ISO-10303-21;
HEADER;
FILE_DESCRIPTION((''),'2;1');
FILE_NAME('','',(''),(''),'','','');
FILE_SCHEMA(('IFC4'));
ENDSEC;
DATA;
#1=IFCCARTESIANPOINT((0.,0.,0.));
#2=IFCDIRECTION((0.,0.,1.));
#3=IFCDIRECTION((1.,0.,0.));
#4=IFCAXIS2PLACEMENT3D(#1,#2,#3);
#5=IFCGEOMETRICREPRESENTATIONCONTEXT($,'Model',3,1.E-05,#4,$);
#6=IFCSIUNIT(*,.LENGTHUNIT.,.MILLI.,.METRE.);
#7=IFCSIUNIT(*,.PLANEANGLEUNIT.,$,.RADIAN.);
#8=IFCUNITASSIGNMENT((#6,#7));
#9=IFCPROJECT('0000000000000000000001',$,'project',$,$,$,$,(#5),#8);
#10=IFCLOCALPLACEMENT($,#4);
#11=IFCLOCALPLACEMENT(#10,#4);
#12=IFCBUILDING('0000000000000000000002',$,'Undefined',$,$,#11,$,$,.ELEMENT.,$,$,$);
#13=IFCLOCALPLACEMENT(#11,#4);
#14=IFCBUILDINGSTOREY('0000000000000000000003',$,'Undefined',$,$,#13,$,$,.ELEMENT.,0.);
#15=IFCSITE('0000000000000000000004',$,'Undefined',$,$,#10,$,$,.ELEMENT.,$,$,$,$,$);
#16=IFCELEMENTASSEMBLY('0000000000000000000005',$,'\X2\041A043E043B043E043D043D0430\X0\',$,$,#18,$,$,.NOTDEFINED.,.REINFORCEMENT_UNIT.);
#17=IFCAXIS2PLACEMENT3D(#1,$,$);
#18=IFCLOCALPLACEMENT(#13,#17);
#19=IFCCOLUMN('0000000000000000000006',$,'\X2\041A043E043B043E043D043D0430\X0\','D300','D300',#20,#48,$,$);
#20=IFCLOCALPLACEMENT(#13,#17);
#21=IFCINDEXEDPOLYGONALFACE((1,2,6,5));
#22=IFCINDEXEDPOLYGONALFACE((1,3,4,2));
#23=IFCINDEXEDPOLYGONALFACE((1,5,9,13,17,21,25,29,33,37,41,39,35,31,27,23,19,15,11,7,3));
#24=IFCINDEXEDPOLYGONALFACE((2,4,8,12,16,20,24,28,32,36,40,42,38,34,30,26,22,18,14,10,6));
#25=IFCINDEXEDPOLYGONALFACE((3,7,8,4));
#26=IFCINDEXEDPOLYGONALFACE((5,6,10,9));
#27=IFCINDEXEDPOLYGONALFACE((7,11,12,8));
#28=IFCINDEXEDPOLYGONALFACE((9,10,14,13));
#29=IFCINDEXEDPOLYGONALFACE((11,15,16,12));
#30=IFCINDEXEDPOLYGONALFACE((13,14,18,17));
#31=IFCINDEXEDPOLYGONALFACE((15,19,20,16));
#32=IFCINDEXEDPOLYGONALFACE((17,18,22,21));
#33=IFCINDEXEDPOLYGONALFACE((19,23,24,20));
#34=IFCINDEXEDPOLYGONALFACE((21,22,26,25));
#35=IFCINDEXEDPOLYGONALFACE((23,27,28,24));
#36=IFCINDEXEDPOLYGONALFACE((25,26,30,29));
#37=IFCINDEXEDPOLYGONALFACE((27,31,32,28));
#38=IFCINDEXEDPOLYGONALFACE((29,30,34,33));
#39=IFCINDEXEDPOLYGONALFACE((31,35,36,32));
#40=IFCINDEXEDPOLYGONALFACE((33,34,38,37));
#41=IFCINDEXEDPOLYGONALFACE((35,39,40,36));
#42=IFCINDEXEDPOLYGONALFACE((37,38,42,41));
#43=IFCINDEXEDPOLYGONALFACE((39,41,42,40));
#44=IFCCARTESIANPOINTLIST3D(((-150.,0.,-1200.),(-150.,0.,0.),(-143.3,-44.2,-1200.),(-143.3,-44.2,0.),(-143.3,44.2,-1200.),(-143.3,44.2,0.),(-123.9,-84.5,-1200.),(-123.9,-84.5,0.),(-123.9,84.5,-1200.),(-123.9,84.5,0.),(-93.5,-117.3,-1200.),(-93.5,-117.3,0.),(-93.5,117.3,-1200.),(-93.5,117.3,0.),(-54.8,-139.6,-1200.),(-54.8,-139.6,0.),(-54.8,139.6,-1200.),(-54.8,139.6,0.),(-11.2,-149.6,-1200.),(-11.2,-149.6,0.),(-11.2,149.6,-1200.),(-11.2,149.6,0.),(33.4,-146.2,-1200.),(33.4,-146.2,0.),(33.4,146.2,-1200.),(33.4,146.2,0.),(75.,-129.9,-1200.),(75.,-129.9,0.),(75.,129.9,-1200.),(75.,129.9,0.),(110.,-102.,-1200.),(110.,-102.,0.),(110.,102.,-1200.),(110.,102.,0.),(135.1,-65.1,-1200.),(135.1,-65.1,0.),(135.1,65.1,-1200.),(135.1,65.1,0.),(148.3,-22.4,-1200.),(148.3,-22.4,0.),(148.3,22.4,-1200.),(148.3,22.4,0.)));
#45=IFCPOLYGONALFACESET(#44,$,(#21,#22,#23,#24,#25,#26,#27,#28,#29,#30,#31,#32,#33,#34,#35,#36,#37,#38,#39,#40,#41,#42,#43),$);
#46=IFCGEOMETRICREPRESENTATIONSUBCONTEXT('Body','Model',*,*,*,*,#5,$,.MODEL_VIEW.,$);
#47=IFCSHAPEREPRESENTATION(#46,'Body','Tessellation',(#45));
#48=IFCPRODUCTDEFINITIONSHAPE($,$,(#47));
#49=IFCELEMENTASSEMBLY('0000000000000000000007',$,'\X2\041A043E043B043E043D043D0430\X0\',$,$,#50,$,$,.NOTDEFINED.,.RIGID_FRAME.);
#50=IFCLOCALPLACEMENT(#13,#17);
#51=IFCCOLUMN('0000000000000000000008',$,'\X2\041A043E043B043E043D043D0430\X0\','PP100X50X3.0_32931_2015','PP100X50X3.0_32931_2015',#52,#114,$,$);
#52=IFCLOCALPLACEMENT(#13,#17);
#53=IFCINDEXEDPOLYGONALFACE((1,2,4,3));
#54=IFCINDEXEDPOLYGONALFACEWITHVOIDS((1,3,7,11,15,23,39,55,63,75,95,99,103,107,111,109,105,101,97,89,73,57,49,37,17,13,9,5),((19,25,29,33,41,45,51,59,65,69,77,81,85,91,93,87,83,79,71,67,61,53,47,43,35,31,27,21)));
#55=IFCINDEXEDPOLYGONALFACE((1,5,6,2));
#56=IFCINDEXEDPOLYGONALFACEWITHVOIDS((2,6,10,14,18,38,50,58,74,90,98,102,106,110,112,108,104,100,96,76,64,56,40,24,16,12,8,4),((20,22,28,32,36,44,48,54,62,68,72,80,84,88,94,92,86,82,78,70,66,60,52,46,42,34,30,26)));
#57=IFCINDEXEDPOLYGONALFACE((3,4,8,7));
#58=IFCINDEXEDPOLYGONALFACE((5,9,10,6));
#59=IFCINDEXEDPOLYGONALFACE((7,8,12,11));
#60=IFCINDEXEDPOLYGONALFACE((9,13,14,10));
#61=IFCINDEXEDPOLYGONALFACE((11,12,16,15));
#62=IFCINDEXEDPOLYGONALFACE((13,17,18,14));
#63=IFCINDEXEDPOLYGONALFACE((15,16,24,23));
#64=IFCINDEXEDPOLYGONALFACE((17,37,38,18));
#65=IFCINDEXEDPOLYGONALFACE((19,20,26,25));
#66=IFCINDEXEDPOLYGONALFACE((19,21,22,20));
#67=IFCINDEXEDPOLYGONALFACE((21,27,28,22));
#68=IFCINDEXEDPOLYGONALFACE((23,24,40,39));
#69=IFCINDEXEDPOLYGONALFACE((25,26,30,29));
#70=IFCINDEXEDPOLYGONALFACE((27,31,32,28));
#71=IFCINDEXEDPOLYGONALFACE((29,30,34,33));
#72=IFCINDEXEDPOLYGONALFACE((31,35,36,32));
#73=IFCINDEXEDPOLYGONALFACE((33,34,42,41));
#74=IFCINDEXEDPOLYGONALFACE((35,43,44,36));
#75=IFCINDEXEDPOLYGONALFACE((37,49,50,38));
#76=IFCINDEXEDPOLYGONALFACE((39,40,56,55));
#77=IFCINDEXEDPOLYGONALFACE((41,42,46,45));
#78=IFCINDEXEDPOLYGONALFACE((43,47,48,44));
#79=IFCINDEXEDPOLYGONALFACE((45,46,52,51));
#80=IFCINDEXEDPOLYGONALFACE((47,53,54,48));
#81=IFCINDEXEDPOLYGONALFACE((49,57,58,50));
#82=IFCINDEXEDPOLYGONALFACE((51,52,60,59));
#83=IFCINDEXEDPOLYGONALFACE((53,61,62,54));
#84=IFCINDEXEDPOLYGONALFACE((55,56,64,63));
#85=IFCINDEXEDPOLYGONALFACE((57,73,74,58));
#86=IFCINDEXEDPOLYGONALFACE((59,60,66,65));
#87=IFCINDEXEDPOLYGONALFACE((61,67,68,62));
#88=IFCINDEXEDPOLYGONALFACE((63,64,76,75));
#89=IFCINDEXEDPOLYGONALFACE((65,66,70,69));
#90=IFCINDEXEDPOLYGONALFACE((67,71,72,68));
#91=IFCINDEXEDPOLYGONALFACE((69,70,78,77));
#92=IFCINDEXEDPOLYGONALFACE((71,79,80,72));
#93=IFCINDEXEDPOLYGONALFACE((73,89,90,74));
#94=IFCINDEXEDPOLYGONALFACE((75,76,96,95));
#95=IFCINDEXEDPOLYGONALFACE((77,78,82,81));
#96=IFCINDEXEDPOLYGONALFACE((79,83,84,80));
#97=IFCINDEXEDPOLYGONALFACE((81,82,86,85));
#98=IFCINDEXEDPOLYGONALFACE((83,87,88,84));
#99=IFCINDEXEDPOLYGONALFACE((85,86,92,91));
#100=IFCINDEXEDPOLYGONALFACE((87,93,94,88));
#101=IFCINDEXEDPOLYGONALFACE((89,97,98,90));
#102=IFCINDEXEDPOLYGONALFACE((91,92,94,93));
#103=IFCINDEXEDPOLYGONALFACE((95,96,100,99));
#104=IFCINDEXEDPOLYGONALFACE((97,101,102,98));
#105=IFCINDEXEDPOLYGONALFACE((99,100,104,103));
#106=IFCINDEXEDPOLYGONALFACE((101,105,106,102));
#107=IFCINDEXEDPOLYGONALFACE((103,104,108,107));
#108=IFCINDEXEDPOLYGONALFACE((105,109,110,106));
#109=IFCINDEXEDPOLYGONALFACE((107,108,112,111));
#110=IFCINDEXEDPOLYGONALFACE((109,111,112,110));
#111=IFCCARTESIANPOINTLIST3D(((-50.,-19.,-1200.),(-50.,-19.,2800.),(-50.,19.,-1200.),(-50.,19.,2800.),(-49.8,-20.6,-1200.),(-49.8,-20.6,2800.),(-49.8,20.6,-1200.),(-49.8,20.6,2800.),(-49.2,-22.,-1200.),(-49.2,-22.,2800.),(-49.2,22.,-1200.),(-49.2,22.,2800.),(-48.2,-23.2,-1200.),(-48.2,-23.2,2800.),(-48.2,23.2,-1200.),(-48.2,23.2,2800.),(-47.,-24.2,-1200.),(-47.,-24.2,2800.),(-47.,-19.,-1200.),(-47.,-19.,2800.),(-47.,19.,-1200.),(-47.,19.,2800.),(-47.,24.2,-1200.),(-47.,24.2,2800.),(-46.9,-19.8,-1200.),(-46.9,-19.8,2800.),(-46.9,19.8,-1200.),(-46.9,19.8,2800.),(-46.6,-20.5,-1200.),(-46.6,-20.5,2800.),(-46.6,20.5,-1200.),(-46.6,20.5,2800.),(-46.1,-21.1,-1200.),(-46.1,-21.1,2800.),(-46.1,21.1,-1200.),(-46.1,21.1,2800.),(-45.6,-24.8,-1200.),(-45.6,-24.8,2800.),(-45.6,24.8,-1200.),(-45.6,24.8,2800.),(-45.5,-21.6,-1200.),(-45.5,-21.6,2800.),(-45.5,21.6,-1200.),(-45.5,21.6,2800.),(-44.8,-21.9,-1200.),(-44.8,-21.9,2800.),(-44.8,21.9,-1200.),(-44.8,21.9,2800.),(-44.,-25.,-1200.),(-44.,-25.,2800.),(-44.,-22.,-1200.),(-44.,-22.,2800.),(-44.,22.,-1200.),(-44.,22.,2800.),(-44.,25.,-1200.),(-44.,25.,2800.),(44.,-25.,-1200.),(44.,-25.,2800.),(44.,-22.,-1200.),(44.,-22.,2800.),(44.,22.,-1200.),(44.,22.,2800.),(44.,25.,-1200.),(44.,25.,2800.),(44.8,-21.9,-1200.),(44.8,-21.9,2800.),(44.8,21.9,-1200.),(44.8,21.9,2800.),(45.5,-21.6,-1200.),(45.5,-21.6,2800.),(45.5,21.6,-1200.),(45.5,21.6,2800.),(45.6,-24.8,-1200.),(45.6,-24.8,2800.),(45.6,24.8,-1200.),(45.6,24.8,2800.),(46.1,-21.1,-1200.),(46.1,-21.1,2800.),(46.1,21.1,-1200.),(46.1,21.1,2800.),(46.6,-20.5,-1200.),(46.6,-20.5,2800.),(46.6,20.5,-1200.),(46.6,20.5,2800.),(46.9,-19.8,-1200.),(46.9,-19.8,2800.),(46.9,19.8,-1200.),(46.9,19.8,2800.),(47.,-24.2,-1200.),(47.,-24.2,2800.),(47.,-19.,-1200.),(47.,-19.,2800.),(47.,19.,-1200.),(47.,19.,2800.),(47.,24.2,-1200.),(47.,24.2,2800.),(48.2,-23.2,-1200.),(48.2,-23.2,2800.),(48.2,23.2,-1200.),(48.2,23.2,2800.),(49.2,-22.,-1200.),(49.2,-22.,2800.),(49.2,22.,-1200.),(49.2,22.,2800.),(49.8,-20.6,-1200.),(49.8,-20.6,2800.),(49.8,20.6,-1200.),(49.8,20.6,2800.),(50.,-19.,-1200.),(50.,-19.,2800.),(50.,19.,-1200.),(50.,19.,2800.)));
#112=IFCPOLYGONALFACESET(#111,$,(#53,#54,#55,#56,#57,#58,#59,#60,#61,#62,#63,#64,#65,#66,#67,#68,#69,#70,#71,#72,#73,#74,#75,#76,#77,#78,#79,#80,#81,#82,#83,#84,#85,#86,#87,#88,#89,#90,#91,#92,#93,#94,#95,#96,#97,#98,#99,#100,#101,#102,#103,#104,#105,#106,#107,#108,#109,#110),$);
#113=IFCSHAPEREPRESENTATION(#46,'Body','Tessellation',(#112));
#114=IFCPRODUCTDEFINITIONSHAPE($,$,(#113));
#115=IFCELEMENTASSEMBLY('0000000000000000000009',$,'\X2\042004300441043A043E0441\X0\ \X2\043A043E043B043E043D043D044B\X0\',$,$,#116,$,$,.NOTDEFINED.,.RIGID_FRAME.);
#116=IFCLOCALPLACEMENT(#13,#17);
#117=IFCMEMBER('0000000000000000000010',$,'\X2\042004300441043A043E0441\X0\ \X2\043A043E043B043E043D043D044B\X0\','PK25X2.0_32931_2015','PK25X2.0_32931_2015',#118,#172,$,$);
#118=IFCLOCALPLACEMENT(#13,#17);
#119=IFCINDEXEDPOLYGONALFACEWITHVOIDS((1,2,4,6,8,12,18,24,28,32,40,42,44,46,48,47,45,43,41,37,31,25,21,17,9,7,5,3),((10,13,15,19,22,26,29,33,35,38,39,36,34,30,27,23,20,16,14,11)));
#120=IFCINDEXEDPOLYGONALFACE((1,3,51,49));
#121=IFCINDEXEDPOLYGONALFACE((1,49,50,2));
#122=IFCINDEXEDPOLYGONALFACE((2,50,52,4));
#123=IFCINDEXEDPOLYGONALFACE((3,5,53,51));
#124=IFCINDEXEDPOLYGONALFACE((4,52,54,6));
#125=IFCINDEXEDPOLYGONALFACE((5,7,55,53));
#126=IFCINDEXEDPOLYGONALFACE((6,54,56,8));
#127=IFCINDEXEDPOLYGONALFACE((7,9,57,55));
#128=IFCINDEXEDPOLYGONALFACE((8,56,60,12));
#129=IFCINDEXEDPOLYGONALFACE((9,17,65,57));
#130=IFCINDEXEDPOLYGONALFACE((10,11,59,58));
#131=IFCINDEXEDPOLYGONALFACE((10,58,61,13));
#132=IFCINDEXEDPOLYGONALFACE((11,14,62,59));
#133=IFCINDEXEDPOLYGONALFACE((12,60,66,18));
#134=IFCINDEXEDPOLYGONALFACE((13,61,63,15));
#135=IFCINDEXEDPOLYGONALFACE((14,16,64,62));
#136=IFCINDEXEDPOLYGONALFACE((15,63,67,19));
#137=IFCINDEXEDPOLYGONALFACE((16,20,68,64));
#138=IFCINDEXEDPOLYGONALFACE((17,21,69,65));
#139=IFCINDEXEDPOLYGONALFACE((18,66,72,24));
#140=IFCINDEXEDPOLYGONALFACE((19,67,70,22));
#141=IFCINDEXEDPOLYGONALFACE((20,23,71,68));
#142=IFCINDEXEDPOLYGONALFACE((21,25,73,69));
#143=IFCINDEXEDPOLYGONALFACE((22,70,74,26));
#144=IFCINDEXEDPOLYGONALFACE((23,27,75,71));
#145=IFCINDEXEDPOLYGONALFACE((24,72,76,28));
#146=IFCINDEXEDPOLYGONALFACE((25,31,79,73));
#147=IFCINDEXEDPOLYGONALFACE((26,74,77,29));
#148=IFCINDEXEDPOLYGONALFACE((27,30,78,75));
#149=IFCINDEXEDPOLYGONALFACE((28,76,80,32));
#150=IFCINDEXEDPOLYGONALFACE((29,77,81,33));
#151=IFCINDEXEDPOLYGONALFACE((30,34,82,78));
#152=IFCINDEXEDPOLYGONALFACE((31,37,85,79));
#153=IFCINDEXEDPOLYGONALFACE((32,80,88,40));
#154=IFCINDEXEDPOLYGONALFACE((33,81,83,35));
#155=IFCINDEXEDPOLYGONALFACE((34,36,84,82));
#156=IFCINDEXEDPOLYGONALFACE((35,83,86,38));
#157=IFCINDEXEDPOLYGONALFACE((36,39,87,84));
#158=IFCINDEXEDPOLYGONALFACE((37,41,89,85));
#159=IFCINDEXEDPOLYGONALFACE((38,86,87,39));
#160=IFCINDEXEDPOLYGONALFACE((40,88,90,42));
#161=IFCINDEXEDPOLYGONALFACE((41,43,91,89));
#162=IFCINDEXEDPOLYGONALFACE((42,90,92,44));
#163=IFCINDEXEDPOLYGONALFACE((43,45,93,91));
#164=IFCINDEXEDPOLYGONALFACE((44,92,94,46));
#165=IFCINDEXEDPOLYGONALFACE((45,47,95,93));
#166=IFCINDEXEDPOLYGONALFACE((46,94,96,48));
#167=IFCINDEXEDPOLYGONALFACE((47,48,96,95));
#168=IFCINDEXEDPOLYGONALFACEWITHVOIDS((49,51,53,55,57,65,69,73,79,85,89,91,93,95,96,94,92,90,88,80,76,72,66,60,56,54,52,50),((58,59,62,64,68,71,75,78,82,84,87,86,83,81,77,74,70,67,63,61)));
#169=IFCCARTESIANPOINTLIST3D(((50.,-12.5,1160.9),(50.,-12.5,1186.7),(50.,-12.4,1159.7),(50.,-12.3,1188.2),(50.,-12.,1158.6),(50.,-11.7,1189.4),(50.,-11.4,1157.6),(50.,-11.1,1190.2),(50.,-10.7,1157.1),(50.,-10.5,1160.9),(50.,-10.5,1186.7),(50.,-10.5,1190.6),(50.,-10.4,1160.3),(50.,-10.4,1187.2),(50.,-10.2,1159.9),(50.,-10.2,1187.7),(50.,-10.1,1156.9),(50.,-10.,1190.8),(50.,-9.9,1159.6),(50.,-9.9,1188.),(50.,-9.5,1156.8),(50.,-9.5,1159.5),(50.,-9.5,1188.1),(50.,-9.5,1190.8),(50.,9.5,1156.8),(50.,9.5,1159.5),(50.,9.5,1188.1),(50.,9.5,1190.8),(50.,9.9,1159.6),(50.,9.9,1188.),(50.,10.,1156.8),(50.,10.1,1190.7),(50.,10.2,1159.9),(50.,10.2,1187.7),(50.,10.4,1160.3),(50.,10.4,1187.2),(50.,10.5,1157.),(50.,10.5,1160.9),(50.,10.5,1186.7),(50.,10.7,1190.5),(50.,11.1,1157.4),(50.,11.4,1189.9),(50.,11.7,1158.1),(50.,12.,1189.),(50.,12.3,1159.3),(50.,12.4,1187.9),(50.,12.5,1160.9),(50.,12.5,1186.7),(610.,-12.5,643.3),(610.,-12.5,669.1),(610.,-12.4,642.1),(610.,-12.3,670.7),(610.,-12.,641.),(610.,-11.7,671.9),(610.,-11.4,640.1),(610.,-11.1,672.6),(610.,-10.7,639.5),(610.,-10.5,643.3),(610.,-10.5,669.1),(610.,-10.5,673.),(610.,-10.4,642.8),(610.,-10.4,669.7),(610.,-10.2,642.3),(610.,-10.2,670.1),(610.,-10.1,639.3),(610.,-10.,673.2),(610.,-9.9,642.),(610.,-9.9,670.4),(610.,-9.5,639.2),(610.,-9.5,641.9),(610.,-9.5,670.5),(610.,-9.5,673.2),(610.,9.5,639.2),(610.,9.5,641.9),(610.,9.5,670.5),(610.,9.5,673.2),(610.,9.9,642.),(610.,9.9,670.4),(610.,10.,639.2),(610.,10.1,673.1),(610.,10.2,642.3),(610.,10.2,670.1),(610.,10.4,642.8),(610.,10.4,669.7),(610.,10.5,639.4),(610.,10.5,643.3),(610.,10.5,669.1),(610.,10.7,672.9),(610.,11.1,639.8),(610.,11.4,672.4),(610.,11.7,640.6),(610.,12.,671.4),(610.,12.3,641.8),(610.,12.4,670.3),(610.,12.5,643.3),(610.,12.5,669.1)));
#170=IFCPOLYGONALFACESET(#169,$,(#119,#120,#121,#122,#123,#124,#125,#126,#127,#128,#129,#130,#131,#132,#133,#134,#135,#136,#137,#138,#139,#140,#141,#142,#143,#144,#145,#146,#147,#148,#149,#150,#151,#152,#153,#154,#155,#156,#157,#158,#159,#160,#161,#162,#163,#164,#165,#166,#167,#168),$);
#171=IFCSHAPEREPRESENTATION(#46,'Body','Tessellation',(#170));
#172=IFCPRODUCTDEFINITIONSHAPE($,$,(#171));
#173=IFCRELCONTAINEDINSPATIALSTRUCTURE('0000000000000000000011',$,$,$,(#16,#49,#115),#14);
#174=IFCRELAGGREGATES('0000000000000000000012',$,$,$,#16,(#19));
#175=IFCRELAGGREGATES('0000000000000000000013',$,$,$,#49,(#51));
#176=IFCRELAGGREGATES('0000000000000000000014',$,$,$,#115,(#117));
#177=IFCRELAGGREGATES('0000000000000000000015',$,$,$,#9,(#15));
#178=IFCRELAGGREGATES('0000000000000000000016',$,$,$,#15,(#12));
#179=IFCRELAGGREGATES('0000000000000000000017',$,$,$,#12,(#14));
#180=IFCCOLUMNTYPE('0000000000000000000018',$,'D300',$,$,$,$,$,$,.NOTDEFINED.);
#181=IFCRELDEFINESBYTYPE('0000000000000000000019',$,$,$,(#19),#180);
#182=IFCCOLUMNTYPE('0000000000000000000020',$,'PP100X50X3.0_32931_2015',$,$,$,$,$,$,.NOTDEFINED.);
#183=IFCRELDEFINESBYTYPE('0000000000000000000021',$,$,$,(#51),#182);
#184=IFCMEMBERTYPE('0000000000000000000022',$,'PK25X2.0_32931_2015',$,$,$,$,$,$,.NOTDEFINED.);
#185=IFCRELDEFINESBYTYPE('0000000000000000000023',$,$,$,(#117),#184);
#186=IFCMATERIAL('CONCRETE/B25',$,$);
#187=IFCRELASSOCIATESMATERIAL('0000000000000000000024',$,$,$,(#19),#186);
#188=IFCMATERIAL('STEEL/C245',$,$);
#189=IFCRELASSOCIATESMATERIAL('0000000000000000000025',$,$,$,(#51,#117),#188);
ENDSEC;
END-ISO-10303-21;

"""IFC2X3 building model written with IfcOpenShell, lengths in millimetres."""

from ifc_helpers import new_model, si_unit, frame, origin_with_axes, origin_2d_with_axis, place, context, subcontext, project, spatial, hollow_rectangle, circle, extrude, clip, halfspace, material, type_object, element, aggregate, save


model = new_model("IFC2X3")

# Units and contexts
model_context = context("Model", 3, precision=1e-05, world=origin_with_axes())
body_context = subcontext(model_context, "Body", "Model", "MODEL_VIEW")
ifc_project = project(units=[si_unit("LENGTHUNIT", "METRE", prefix="MILLI"), si_unit("PLANEANGLEUNIT", "RADIAN")], contexts=[model_context])

# Site, building, storey
site_placement = place(None, origin_with_axes())
site = spatial("IfcSite", under=ifc_project, at=site_placement, Name="Undefined", CompositionType="ELEMENT")
building_placement = place(site_placement, origin_with_axes())
building = spatial("IfcBuilding", under=site, at=building_placement, Name="Undefined", CompositionType="ELEMENT")
storey_placement = place(building_placement, origin_with_axes())
storey = spatial("IfcBuildingStorey", under=building, at=storey_placement, Name="Undefined", CompositionType="ELEMENT", Elevation=0.0)

# Element assemblies, columns
assembly_1_placement = place(storey_placement, origin_with_axes())
assembly_1 = element("IfcElementAssembly", 1, at=assembly_1_placement, inside=storey, Name="Колонна", AssemblyPlace="NOTDEFINED", PredefinedType="REINFORCEMENT_UNIT")
ifc_material_1 = material(Name="CONCRETE/B25")
column_type_1 = type_object("IfcColumnType", Name="D300", PredefinedType="NOTDEFINED")
column_1_placement = place(assembly_1_placement, frame((0.0, 0.0, -1200.0), z_axis=(0.0, 0.0, 1.0), x_axis=(0.0, 1.0, 0.0)))
column_1 = element("IfcColumn", 2, at=column_1_placement, type_object=column_type_1, material=ifc_material_1, Name="Колонна", Description="D300", ObjectType="D300", context=body_context, shape_type="SweptSolid", body=[
    extrude(circle(Radius=150.0, at=origin_2d_with_axis()), frame((0.0, 0.0, 1200.0), z_axis=(0.0, 0.0, -1.0), x_axis=(0.0, 1.0, 0.0)), (0.0, 0.0, 1.0), 1200.0),
])
aggregate(assembly_1, [column_1])
assembly_2_placement = place(storey_placement, origin_with_axes())
assembly_2 = element("IfcElementAssembly", 3, at=assembly_2_placement, inside=storey, Name="Колонна", AssemblyPlace="NOTDEFINED", PredefinedType="RIGID_FRAME")
ifc_material_2 = material(Name="STEEL/C245")
column_type_2 = type_object("IfcColumnType", Name="PP100X50X3.0_32931_2015", PredefinedType="NOTDEFINED")
column_2_placement = place(assembly_2_placement, frame((0.0, 0.0, -1200.0), z_axis=(0.0, 0.0, 1.0), x_axis=(-1.0, 0.0, 0.0)))
column_2 = element("IfcColumn", 4, at=column_2_placement, type_object=column_type_2, material=ifc_material_2, Name="Колонна", Description="PP100X50X3.0_32931_2015", ObjectType="PP100X50X3.0_32931_2015", context=body_context, shape_type="SweptSolid", body=[
    extrude(hollow_rectangle(XDim=50.0, YDim=100.0, WallThickness=3.0, InnerFilletRadius=3.0, OuterFilletRadius=6.0, at=origin_2d_with_axis()), frame((0.0, 0.0, 4000.0), z_axis=(0.0, 0.0, -1.0), x_axis=(0.0, 1.0, 0.0)), (0.0, 0.0, 1.0), 4000.0),
])
aggregate(assembly_2, [column_2])

# Element assembly, member
member_type = type_object("IfcMemberType", Name="PK25X2.0_32931_2015", PredefinedType="NOTDEFINED")
assembly_3_placement = place(storey_placement, origin_with_axes())
assembly_3 = element("IfcElementAssembly", 5, at=assembly_3_placement, inside=storey, Name="Раскос колонны", AssemblyPlace="NOTDEFINED", PredefinedType="RIGID_FRAME")
member_1_placement = place(assembly_3_placement, frame((660.0, 0.0, 610.0), z_axis=(0.678742, 0.0, 0.734377), x_axis=(-0.734377, 0.0, 0.678742)))
member_1 = element("IfcMember", 6, at=member_1_placement, type_object=member_type, material=ifc_material_2, Name="Раскос колонны", Description="PK25X2.0_32931_2015", ObjectType="PK25X2.0_32931_2015", context=body_context, shape_type="Clipping", body=[
    clip(clip(extrude(hollow_rectangle(XDim=25.0, YDim=25.0, WallThickness=2.0, InnerFilletRadius=1.0, OuterFilletRadius=3.0, at=origin_2d_with_axis()), frame((854.0, 0.0, 0.0), z_axis=(-1.0, 0.0, 0.0), x_axis=(0.0, -1.0, 0.0)), (0.0, 0.0, 1.0), 809.2), halfspace(frame((640.5, 0.0, -205.7), z_axis=(0.734377, 0.0, -0.678742), x_axis=(0.678742, 0.0, 0.734377)), False)), halfspace(frame((258.5, 0.0, 206.0), z_axis=(0.734377, 0.0, -0.678742), x_axis=(0.678742, 0.0, 0.734377)), True)),
])
aggregate(assembly_3, [member_1])

save(model, "model.ifc")
